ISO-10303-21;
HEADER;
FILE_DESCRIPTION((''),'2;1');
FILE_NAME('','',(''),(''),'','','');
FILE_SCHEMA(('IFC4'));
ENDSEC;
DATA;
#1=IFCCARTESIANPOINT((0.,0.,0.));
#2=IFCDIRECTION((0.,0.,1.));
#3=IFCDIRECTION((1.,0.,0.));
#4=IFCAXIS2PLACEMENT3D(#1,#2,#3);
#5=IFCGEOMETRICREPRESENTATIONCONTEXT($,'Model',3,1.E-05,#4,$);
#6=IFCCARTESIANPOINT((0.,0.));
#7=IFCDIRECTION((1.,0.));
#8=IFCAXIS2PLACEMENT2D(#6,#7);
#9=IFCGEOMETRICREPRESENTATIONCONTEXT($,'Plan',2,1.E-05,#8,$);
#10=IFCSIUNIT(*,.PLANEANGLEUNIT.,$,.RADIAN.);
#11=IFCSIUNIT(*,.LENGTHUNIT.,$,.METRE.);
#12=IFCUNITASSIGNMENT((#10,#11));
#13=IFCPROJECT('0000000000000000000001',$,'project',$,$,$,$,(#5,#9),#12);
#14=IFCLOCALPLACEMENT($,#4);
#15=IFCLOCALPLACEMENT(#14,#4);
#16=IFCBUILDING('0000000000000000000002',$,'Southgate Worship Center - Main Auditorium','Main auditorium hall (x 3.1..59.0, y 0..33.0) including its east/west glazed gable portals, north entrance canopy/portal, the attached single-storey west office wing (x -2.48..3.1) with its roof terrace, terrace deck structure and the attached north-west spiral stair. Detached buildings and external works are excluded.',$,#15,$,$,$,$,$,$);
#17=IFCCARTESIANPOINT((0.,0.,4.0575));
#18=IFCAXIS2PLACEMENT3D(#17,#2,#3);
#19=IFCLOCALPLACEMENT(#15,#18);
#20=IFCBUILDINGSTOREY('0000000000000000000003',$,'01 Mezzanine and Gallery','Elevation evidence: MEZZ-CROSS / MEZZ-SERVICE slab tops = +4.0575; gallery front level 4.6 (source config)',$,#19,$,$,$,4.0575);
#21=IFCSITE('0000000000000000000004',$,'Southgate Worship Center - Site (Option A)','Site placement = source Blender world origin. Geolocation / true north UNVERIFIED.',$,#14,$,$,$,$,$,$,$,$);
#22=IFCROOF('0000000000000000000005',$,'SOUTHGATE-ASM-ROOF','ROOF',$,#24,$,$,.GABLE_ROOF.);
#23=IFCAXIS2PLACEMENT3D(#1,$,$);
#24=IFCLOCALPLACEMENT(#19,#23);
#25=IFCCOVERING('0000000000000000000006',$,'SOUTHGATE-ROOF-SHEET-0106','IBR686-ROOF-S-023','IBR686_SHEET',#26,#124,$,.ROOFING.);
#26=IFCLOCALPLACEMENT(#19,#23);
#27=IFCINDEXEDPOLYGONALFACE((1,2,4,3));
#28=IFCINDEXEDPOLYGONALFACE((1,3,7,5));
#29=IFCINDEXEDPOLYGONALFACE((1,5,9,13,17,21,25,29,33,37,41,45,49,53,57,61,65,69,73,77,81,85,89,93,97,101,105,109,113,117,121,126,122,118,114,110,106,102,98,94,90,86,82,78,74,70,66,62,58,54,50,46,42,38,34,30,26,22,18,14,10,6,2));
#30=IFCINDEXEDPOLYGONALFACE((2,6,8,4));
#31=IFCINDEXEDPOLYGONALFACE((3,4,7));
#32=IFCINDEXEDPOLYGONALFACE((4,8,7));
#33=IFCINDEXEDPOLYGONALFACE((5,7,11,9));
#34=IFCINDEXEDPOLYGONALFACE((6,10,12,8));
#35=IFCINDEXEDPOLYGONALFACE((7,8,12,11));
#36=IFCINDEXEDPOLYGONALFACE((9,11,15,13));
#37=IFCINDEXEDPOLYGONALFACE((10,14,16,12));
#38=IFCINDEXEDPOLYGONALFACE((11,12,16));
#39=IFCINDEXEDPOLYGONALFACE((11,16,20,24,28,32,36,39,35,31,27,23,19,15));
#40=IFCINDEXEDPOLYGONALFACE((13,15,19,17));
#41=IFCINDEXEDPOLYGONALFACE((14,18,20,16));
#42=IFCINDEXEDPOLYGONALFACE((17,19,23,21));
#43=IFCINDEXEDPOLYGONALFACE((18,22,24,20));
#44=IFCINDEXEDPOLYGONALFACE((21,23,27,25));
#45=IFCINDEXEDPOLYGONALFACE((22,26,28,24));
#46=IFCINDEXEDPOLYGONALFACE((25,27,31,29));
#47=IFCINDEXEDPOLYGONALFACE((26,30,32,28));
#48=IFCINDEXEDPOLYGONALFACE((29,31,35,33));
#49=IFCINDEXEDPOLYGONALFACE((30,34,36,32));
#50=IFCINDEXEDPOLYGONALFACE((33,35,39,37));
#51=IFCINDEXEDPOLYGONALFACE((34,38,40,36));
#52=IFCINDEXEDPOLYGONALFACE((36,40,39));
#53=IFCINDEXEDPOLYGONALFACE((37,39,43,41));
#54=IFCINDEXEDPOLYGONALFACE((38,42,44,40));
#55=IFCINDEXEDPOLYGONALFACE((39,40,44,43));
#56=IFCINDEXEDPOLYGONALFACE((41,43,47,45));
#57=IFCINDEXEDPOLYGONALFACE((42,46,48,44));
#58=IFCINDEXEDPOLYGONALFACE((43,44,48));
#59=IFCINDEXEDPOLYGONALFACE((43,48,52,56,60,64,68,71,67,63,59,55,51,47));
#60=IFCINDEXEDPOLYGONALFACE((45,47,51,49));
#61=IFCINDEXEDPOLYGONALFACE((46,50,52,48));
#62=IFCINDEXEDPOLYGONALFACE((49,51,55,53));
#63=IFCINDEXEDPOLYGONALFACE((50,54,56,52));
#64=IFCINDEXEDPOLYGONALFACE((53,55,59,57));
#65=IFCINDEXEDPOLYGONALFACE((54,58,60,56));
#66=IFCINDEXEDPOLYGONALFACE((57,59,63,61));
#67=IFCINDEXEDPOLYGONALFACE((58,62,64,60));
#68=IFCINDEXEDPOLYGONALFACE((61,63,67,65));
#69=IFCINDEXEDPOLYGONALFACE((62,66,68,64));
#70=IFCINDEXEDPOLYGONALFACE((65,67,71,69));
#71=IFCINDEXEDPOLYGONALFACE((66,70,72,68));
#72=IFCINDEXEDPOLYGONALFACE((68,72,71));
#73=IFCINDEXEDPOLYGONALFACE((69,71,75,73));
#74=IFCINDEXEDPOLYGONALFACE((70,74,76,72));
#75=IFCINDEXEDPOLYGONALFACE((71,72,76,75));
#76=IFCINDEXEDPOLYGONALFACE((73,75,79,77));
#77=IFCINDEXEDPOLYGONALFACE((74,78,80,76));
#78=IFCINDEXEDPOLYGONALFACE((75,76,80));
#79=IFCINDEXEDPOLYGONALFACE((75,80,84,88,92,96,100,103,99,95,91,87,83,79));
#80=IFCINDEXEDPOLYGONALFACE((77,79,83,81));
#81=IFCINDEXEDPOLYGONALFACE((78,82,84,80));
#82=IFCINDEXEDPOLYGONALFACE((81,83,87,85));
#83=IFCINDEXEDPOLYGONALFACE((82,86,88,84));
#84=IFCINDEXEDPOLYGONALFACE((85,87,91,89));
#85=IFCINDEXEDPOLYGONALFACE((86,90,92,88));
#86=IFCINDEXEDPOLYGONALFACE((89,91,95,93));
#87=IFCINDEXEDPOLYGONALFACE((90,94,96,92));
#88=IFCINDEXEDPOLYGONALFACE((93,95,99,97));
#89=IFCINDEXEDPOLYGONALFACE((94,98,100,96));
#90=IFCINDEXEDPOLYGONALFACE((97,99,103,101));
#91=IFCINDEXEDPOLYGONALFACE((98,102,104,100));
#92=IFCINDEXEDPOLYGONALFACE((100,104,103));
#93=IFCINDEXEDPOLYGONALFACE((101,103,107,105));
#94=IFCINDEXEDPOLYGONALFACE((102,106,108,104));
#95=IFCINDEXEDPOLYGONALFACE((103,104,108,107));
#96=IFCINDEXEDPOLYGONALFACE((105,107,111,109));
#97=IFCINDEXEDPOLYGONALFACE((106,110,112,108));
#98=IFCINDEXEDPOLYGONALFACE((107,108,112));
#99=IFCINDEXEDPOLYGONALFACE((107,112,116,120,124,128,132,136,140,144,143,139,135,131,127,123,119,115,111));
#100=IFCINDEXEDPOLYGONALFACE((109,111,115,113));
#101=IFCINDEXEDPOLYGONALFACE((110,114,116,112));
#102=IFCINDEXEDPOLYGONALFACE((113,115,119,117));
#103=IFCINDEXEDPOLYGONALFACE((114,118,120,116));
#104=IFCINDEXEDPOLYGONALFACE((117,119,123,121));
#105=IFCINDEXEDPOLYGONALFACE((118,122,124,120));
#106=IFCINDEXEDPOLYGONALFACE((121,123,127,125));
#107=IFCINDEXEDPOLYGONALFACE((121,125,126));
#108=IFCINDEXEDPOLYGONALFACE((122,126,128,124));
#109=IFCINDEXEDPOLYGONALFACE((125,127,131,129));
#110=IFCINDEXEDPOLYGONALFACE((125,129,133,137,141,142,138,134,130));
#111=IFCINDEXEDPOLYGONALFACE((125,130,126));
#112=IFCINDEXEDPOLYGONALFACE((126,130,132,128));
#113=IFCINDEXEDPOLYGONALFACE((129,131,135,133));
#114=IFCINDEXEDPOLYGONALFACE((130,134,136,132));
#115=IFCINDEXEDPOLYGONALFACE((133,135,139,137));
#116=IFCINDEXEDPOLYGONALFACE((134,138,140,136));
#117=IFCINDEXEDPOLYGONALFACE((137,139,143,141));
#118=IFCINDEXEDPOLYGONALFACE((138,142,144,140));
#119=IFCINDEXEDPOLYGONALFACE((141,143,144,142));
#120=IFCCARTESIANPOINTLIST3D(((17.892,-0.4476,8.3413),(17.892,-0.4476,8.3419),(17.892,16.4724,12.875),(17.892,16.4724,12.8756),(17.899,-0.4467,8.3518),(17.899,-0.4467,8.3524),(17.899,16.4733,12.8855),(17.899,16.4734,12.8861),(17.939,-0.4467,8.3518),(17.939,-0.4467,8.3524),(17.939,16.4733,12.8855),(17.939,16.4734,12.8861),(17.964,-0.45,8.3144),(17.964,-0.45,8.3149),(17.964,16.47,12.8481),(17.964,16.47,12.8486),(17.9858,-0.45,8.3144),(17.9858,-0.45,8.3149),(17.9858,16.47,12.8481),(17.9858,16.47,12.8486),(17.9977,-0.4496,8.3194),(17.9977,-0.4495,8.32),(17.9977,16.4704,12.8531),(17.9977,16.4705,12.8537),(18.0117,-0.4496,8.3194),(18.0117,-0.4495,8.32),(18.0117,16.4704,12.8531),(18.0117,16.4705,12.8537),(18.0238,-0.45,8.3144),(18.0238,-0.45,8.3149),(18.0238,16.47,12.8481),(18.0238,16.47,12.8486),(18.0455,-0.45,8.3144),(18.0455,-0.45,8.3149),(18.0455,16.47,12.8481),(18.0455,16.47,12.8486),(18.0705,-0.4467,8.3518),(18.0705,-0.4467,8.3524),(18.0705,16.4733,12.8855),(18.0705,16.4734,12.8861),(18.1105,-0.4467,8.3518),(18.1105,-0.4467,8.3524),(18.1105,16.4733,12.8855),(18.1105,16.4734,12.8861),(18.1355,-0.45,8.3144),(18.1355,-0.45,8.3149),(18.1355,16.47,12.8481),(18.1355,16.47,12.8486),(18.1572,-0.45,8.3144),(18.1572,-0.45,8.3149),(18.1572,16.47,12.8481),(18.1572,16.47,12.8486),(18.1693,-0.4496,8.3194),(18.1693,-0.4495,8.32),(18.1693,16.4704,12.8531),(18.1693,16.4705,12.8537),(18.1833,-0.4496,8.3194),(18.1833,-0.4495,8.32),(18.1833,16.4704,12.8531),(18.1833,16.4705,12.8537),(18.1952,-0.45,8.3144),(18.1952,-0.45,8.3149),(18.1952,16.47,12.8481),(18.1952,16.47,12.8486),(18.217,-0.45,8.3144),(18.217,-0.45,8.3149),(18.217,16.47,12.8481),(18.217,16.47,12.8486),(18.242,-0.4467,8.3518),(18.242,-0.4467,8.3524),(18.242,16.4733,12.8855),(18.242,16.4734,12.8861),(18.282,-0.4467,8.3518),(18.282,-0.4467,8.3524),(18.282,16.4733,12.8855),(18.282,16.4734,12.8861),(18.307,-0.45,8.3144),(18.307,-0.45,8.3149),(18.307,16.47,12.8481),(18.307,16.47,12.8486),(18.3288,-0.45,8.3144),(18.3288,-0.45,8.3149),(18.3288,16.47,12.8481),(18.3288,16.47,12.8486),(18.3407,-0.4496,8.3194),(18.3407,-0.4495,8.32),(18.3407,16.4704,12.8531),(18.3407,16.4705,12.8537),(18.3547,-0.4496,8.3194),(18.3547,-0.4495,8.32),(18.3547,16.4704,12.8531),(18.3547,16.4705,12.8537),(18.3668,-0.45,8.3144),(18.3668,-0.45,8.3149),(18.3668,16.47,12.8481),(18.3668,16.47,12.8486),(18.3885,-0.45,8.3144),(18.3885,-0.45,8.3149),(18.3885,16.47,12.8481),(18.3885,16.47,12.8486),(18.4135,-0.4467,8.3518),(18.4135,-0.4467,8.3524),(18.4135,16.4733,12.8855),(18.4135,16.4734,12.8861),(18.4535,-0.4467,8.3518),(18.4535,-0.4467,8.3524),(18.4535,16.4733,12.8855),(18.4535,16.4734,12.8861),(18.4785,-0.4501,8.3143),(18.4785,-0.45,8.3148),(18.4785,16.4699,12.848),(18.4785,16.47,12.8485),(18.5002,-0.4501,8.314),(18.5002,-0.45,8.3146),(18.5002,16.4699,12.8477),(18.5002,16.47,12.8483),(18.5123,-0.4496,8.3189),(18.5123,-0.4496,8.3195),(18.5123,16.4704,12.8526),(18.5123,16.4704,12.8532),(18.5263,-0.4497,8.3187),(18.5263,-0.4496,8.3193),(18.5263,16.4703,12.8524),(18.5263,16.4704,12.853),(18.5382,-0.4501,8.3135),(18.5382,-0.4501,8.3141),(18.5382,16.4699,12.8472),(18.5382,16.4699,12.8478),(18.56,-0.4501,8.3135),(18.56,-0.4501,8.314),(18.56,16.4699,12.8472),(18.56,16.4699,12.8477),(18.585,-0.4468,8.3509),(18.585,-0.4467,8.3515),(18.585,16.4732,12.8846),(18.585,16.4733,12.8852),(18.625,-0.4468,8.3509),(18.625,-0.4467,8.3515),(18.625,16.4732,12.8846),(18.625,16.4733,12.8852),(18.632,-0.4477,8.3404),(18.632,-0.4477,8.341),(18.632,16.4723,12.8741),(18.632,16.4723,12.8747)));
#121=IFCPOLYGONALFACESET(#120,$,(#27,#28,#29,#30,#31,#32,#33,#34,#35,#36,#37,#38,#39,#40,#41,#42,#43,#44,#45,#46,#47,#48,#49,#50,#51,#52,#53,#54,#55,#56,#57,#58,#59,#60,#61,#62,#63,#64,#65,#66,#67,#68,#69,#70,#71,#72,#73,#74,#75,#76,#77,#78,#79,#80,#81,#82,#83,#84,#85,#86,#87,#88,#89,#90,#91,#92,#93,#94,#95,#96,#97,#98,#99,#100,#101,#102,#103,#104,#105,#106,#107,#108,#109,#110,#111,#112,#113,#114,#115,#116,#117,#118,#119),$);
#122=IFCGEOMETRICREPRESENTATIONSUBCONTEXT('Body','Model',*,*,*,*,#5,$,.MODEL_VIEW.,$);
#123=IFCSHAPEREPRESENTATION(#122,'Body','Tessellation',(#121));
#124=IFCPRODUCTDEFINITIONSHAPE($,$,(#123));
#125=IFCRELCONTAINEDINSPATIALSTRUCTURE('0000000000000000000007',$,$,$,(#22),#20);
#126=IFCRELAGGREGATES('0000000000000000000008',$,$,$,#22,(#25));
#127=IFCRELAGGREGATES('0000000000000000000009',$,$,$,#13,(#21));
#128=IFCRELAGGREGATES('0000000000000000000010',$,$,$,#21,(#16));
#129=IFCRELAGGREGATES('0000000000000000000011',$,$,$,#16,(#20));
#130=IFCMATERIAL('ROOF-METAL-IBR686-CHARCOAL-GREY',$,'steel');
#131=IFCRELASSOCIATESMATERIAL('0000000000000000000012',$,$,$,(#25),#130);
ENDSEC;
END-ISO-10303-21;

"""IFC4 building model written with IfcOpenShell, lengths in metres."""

from ifc_helpers import new_model, si_unit, frame, origin_with_axes, origin_2d_with_axis, place, context, subcontext, project, spatial, indexed_curve, outline, extrude, clip, halfspace, material, element, aggregate, save


model = new_model("IFC4")

# Units and contexts
model_context = context("Model", 3, precision=1e-05, world=origin_with_axes())
plan_context = context("Plan", 2, precision=1e-05, world=origin_2d_with_axis())
body_context = subcontext(model_context, "Body", "Model", "MODEL_VIEW")
ifc_project = project(units=[si_unit("PLANEANGLEUNIT", "RADIAN"), si_unit("LENGTHUNIT", "METRE")], contexts=[model_context, plan_context])

# Site, building, storey
site_placement = place(None, origin_with_axes())
site = spatial("IfcSite", under=ifc_project, at=site_placement, Name="Southgate Worship Center - Site (Option A)", Description="Site placement = source Blender world origin. Geolocation / true north UNVERIFIED.")
building_placement = place(site_placement, origin_with_axes())
building = spatial("IfcBuilding", under=site, at=building_placement, Name="Southgate Worship Center - Main Auditorium", Description="Main auditorium hall (x 3.1..59.0, y 0..33.0) including its east/west glazed gable portals, north entrance canopy/portal, the attached single-storey west office wing (x -2.48..3.1) with its roof terrace, terrace deck structure and the attached north-west spiral stair. Detached buildings and external works are excluded.")
storey_placement = place(building_placement, frame((0.0, 0.0, 4.0575), z_axis=(0.0, 0.0, 1.0), x_axis=(1.0, 0.0, 0.0)))
storey = spatial("IfcBuildingStorey", under=building, at=storey_placement, Name="01 Mezzanine and Gallery", Description="Elevation evidence: MEZZ-CROSS / MEZZ-SERVICE slab tops = +4.0575; gallery front level 4.6 (source config)", Elevation=4.0575)

# Roof, covering
roof_placement = place(storey_placement, origin_with_axes())
roof = element("IfcRoof", 1, at=roof_placement, inside=storey, Name="SOUTHGATE-ASM-ROOF", Description="ROOF", PredefinedType="GABLE_ROOF")
ifc_material_1 = material(Name="ROOF-METAL-IBR686-CHARCOAL-GREY", Category="steel")
covering_1_placement = place(roof_placement, frame((17.892, -0.4501, 8.3135), z_axis=(0.0, 0.0, 1.0), x_axis=(1.0, 0.0, 0.0)))
covering_1 = element("IfcCovering", 2, at=covering_1_placement, material=ifc_material_1, Name="SOUTHGATE-ROOF-SHEET-0106", Description="IBR686-ROOF-S-023", ObjectType="IBR686_SHEET", PredefinedType="ROOFING", context=body_context, shape_type="Clipping", body=[
    clip(clip(extrude(outline(indexed_curve([(0.0, 0.0), (0.025, 0.0353), (0.065, 0.0353), (0.072, 0.0254), (0.072, 0.0259), (0.065, 0.0358), (0.025, 0.0358), (0.0, 0.0005), (-0.0217, 0.0005), (-0.0337, 0.0053), (-0.0477, 0.0053), (-0.0597, 0.0005), (-0.0815, 0.0005), (-0.1065, 0.0358), (-0.1465, 0.0358), (-0.1715, 0.0005), (-0.1932, 0.0005), (-0.2052, 0.0053), (-0.2192, 0.0053), (-0.2312, 0.0005), (-0.253, 0.0005), (-0.278, 0.0358), (-0.318, 0.0358), (-0.343, 0.0005), (-0.3647, 0.0005), (-0.3767, 0.0053), (-0.3907, 0.0053), (-0.4028, 0.0005), (-0.4245, 0.0005), (-0.4495, 0.0358), (-0.4895, 0.0358), (-0.5145, 0.0004), (-0.5362, 0.0002), (-0.5483, 0.0048), (-0.5623, 0.0046), (-0.5742, -0.0003), (-0.596, -0.0004), (-0.621, 0.0349), (-0.661, 0.0349), (-0.668, 0.0251), (-0.668, 0.0246), (-0.661, 0.0344), (-0.621, 0.0344), (-0.596, -0.0009), (-0.5742, -0.0008), (-0.5623, 0.0041), (-0.5483, 0.0043), (-0.5362, -0.0003), (-0.5145, -0.0001), (-0.4895, 0.0353), (-0.4495, 0.0353), (-0.4245, 0.0), (-0.4028, 0.0), (-0.3907, 0.0048), (-0.3767, 0.0048), (-0.3647, 0.0), (-0.343, 0.0), (-0.318, 0.0353), (-0.278, 0.0353), (-0.253, 0.0), (-0.2312, 0.0), (-0.2192, 0.0048), (-0.2052, 0.0048), (-0.1932, 0.0), (-0.1715, 0.0), (-0.1465, 0.0353), (-0.1065, 0.0353), (-0.0815, 0.0), (-0.0597, 0.0), (-0.0477, 0.0048), (-0.0337, 0.0048), (-0.0217, 0.0), (0.0, 0.0)], self_intersect=False)), frame((0.072, -0.0003, 0.0008), z_axis=(0.0, 0.965926, 0.258819), x_axis=(-1.0, 0.0, 0.0)), (0.0, 0.0, 1.0), 17.5303), halfspace(frame((0.37, 0.0012, 0.014), z_axis=(0.0, -0.996022, 0.089113), x_axis=(1.0, 0.0, 0.0)), False)), halfspace(frame((0.37, 16.9212, 4.5477), z_axis=(0.0, 0.996021, -0.089119), x_axis=(-1.0, 0.0, 0.0)), False)),
])
aggregate(roof, [covering_1])

save(model, "model.ifc")
